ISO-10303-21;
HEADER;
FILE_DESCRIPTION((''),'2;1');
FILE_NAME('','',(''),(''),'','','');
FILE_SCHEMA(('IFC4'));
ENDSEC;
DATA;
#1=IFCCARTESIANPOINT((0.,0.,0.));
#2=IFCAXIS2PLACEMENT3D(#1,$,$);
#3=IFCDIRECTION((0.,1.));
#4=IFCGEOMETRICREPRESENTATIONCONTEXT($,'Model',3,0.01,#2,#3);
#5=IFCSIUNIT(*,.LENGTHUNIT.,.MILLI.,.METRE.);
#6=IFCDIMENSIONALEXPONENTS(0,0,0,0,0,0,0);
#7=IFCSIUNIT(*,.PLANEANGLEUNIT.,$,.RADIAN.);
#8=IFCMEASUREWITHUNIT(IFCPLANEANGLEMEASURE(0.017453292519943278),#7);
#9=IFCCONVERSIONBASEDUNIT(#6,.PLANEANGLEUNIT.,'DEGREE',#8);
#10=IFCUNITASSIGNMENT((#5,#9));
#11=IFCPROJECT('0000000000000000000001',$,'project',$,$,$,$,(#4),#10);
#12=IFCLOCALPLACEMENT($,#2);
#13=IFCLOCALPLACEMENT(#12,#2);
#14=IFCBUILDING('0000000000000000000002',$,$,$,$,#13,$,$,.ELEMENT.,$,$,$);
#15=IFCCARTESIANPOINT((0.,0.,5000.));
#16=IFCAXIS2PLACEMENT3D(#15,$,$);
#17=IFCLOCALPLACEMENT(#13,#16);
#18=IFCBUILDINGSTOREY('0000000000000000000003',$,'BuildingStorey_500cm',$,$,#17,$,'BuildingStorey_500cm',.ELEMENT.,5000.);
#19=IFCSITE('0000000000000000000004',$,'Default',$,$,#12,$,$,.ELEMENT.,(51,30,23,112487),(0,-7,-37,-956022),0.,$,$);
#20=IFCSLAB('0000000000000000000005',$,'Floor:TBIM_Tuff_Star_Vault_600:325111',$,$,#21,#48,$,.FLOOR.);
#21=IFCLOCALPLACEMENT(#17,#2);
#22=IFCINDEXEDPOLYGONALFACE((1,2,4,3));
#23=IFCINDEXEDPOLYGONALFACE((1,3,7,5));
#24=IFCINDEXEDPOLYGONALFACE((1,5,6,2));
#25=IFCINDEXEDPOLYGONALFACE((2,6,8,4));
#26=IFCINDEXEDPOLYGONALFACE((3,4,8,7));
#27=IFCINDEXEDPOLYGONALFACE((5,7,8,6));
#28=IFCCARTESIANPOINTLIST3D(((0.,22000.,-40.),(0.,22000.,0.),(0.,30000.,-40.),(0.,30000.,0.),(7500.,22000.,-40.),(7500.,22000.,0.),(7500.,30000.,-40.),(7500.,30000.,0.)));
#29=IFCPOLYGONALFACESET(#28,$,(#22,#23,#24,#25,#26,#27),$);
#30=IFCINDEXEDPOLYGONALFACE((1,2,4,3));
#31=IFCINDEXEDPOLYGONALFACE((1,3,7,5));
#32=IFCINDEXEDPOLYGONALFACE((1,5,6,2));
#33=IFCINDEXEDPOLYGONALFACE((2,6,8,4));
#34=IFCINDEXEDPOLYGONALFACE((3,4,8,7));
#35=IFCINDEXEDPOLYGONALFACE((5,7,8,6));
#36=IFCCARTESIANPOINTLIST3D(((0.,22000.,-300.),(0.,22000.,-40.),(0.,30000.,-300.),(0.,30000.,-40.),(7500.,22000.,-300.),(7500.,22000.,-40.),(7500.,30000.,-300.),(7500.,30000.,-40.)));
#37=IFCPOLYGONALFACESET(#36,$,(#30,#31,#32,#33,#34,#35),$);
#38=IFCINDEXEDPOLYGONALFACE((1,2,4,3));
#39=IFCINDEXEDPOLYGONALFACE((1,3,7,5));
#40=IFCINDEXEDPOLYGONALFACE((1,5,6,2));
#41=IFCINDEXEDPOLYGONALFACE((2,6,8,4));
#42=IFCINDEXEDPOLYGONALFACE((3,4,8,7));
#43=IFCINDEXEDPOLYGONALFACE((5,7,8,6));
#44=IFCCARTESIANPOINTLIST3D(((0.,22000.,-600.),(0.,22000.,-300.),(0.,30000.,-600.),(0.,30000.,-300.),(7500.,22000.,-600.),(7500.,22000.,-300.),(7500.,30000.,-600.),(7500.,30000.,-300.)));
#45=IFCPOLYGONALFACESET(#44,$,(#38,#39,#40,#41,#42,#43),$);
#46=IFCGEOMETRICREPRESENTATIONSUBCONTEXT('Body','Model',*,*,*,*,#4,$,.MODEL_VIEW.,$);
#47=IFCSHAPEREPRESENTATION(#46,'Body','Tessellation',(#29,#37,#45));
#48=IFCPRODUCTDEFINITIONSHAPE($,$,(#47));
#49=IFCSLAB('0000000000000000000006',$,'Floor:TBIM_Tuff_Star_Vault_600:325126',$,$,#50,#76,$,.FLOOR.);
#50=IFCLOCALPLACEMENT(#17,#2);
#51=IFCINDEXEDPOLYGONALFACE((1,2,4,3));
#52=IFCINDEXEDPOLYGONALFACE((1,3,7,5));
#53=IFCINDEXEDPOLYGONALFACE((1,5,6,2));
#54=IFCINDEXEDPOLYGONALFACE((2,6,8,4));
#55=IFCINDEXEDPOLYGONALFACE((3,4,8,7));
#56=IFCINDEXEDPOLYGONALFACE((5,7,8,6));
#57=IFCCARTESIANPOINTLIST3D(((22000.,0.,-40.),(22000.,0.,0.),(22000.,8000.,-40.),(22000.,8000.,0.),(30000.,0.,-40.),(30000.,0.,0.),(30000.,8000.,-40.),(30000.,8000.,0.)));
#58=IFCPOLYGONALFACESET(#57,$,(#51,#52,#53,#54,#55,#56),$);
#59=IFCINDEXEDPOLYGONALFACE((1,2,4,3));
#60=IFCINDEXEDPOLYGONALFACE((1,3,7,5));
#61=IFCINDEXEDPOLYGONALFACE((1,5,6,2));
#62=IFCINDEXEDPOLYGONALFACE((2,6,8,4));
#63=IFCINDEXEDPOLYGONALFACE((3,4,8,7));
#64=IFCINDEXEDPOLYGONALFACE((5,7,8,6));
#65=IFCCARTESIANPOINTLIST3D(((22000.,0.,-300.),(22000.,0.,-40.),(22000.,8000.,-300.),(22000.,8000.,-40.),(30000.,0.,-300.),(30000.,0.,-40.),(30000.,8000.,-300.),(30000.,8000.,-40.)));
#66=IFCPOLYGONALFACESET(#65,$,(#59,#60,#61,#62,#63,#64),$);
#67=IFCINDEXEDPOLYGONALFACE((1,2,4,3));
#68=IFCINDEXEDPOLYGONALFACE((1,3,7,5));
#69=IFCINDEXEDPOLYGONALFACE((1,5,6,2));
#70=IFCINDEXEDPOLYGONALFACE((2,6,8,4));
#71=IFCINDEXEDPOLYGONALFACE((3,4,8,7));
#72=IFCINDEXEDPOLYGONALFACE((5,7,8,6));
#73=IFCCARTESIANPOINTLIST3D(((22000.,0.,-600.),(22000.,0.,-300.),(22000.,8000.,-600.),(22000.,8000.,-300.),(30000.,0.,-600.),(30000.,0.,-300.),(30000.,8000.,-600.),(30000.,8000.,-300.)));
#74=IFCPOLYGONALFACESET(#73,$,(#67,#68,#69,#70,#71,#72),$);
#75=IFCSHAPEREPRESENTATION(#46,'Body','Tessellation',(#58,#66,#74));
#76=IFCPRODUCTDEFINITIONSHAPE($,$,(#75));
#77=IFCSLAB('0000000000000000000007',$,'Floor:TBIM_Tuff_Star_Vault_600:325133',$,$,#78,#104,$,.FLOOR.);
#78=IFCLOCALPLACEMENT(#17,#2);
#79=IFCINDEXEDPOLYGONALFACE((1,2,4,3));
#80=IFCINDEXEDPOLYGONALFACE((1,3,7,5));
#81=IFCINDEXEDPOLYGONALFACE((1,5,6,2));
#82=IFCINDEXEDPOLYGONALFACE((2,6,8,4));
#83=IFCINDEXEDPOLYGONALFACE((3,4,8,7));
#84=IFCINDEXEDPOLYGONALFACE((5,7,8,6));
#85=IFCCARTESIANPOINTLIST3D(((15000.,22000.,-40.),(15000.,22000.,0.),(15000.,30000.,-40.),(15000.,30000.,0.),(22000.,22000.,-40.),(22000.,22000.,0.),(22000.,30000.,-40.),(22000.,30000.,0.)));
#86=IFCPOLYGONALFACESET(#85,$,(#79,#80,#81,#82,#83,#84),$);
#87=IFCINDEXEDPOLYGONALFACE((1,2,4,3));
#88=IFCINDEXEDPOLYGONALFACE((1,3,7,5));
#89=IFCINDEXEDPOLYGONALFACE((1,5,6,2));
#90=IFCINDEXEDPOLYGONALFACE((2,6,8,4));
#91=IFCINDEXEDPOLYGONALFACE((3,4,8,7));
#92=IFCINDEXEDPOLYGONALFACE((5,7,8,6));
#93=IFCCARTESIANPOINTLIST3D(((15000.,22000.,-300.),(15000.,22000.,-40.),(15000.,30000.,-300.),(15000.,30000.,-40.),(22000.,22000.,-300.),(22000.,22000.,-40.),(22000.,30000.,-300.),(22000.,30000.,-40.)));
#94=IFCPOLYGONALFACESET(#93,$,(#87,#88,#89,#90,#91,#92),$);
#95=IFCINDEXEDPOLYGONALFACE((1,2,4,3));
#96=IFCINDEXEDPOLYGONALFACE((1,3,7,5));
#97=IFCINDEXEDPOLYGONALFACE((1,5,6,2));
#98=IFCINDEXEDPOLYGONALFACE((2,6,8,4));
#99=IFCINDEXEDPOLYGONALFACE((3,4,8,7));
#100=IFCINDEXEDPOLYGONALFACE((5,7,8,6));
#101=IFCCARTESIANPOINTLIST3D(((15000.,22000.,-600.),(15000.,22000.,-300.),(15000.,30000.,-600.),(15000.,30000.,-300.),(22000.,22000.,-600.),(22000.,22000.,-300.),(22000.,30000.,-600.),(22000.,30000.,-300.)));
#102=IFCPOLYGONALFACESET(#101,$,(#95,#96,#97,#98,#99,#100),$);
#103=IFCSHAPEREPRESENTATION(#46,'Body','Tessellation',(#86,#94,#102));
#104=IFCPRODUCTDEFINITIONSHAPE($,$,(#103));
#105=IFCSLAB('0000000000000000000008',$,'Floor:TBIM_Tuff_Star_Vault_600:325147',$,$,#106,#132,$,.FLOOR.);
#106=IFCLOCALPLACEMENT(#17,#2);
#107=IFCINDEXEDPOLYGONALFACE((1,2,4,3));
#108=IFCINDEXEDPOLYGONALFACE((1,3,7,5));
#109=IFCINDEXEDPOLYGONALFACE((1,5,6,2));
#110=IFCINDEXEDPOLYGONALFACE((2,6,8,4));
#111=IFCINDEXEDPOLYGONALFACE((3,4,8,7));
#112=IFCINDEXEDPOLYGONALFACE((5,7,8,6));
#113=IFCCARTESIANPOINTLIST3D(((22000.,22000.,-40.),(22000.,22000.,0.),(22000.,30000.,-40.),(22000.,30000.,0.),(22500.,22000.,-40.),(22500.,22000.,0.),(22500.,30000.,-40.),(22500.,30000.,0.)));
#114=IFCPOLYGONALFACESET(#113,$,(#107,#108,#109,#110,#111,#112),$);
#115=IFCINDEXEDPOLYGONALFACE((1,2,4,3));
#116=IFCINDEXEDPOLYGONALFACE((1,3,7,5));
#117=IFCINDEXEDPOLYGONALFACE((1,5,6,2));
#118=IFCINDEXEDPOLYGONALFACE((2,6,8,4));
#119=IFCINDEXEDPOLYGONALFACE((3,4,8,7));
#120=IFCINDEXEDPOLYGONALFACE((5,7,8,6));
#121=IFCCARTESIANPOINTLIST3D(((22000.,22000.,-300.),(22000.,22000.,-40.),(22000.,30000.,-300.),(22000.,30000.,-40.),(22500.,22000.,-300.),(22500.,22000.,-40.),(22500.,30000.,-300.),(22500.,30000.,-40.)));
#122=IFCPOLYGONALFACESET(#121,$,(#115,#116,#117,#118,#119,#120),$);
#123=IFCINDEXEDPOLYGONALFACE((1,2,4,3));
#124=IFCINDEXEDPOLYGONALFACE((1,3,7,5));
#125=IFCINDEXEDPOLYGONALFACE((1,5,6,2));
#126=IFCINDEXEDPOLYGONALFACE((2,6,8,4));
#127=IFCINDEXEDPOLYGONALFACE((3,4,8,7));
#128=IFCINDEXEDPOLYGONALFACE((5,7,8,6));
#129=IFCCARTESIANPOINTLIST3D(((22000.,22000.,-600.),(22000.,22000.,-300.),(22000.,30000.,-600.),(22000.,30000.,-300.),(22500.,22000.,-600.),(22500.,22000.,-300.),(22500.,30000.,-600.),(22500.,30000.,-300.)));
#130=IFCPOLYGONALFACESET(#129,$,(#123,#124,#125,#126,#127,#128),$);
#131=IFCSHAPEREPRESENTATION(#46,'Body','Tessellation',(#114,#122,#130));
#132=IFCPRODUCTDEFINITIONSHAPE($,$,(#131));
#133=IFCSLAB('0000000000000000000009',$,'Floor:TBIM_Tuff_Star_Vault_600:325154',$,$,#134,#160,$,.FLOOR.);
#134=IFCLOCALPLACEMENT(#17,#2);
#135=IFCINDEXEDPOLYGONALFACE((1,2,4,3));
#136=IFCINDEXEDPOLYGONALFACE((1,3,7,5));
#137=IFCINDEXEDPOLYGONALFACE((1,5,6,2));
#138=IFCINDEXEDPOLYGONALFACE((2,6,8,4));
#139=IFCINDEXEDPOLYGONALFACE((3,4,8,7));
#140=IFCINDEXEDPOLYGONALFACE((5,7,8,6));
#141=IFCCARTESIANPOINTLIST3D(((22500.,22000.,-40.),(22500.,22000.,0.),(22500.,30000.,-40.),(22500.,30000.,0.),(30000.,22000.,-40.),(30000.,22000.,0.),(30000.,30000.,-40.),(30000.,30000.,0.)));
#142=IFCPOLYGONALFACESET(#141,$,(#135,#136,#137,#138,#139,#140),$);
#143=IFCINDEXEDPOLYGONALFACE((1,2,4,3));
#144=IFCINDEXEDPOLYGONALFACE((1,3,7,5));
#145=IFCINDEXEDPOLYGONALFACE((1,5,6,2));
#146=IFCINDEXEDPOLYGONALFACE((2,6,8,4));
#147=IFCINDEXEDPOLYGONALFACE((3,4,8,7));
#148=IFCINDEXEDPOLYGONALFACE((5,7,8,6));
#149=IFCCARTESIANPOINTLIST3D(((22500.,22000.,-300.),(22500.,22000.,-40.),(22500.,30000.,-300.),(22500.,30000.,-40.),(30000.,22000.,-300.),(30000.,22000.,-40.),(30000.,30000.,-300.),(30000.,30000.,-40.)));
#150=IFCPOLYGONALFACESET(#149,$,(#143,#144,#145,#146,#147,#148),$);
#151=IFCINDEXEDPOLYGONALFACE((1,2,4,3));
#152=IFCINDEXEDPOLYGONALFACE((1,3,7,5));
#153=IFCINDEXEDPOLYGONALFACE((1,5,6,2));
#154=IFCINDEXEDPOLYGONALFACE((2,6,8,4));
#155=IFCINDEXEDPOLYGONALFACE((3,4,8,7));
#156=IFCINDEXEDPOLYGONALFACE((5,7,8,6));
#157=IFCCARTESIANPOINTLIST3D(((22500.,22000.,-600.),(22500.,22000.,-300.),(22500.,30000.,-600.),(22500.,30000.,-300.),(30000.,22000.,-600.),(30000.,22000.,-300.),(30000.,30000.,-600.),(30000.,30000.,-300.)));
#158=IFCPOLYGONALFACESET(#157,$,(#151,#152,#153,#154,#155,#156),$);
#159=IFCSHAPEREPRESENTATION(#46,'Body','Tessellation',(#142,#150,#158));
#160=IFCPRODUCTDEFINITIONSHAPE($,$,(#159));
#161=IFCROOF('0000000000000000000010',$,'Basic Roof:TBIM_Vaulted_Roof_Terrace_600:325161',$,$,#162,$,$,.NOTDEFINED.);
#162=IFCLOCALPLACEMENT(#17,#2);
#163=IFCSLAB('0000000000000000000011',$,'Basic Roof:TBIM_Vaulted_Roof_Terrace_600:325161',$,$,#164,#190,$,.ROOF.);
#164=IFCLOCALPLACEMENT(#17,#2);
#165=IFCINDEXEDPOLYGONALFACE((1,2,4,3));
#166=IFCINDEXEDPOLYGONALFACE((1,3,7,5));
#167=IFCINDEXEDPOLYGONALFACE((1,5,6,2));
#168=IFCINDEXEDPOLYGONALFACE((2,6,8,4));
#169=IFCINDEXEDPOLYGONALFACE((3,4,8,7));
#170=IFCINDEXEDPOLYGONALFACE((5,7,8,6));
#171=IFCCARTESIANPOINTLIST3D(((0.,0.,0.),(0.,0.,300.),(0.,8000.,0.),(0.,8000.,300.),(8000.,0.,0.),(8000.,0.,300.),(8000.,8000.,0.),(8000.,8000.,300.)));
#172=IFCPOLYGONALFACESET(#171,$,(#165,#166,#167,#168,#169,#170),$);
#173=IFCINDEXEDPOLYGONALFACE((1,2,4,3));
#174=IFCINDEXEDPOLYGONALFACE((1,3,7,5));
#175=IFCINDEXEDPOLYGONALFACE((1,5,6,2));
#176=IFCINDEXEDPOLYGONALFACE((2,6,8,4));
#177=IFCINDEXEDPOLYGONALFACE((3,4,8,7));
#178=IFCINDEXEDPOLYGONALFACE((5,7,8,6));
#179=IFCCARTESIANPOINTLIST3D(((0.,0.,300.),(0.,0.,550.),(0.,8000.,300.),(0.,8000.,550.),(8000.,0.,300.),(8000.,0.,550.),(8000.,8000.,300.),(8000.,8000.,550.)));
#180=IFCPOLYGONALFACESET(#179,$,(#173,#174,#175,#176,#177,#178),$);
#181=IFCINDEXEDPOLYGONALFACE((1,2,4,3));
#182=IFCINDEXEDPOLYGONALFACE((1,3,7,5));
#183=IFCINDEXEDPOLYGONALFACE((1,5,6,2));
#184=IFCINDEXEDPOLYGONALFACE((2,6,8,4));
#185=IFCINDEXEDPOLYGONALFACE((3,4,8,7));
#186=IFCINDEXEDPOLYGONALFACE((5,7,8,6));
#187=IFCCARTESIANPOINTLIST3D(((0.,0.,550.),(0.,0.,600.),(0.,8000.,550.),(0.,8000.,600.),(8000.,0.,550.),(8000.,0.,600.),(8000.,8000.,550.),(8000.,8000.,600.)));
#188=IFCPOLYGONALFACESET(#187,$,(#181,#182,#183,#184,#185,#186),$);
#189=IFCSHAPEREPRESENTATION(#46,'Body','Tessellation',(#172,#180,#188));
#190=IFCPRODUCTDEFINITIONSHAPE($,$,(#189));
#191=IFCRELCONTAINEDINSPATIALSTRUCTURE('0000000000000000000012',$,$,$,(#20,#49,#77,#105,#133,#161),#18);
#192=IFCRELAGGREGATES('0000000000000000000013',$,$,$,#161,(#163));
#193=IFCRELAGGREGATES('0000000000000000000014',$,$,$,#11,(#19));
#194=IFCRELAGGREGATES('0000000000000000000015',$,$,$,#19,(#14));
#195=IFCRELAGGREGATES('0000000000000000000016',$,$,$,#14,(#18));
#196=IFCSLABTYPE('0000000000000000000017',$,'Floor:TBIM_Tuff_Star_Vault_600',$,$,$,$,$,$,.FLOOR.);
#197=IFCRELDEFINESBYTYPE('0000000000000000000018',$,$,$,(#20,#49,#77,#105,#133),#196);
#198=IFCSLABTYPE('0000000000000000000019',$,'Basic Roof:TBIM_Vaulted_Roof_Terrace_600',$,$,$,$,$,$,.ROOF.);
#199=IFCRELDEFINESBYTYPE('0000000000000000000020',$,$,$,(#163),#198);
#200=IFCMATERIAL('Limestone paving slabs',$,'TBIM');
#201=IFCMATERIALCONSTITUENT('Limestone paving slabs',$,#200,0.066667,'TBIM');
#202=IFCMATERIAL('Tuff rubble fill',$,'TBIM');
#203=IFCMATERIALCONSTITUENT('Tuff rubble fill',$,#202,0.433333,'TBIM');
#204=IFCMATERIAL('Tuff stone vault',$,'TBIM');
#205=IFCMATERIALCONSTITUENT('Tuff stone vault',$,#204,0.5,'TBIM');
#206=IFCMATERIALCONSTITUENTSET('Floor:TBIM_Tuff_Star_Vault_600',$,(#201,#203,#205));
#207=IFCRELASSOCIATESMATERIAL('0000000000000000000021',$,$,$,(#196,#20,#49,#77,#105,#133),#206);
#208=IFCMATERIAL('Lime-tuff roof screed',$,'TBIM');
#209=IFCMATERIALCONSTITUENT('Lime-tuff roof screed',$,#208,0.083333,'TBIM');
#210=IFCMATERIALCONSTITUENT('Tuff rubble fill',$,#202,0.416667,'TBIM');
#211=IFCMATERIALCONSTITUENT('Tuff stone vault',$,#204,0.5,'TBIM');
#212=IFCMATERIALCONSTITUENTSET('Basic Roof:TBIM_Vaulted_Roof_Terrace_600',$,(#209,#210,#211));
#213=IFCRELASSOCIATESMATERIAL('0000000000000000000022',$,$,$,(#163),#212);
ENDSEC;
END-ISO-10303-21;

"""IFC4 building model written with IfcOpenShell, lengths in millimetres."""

from ifc_helpers import new_model, entity, si_unit, converted_unit, direction, frame, origin, place, context, subcontext, project, spatial, indexed_curve, outline, extrude, material, constituent, constituent_set, type_object, element, aggregate, save


model = new_model("IFC4")

# Units and contexts
model_context = context("Model", 3, precision=0.01, world=origin(), true_north=direction((0.0, 1.0)))
body_context = subcontext(model_context, "Body", "Model", "MODEL_VIEW")
ifc_project = project(units=[si_unit("LENGTHUNIT", "METRE", prefix="MILLI"), converted_unit("PLANEANGLEUNIT", "DEGREE", entity("IfcPlaneAngleMeasure", 0.017453292519943278), si_unit("PLANEANGLEUNIT", "RADIAN"), dimensions=[0, 0, 0, 0, 0, 0, 0])], contexts=[model_context])

# Site, building, storey
site_placement = place(None, origin())
site = spatial("IfcSite", under=ifc_project, at=site_placement, Name="Default", CompositionType="ELEMENT", RefLatitude=(51, 30, 23, 112487), RefLongitude=(0, -7, -37, -956022), RefElevation=0.0)
building_placement = place(site_placement, origin())
building = spatial("IfcBuilding", under=site, at=building_placement, CompositionType="ELEMENT")
storey_placement = place(building_placement, frame((0.0, 0.0, 5000.0)))
storey = spatial("IfcBuildingStorey", under=building, at=storey_placement, Name="BuildingStorey_500cm", LongName="BuildingStorey_500cm", CompositionType="ELEMENT", Elevation=5000.0)

# Slabs
ifc_material_1 = material(Name="Limestone paving slabs", Category="TBIM")
ifc_constituent_1 = constituent(ifc_material_1, Name="Limestone paving slabs", Category="TBIM", fraction=0.066667)
ifc_material_2 = material(Name="Tuff rubble fill", Category="TBIM")
ifc_constituent_2 = constituent(ifc_material_2, Name="Tuff rubble fill", Category="TBIM", fraction=0.433333)
ifc_material_3 = material(Name="Tuff stone vault", Category="TBIM")
ifc_constituent_3 = constituent(ifc_material_3, Name="Tuff stone vault", Category="TBIM", fraction=0.5)
ifc_constituent_set_1 = constituent_set(constituents=[ifc_constituent_1, ifc_constituent_2, ifc_constituent_3], Name="Floor:TBIM_Tuff_Star_Vault_600")
slab_type_1 = type_object("IfcSlabType", Name="Floor:TBIM_Tuff_Star_Vault_600", PredefinedType="FLOOR", material=ifc_constituent_set_1)
slab_1_placement = place(storey_placement, origin())
element("IfcSlab", 1, at=slab_1_placement, inside=storey, type_object=slab_type_1, material=ifc_constituent_set_1, Name="Floor:TBIM_Tuff_Star_Vault_600:325111", PredefinedType="FLOOR", context=body_context, shape_type="SweptSolid", body=[
    extrude(outline(indexed_curve([(-4000.0, -3750.0), (4000.0, -3750.0), (4000.0, 3750.0), (-4000.0, 3750.0), (-4000.0, -3750.0)], self_intersect=False)), frame((3750.0, 26000.0, -40.0), z_axis=(0.0, 0.0, 1.0), x_axis=(0.0, -1.0, 0.0)), (0.0, 0.0, 1.0), 40.0),
    extrude(outline(indexed_curve([(-4000.0, -3750.0), (4000.0, -3750.0), (4000.0, 3750.0), (-4000.0, 3750.0), (-4000.0, -3750.0)], self_intersect=False)), frame((3750.0, 26000.0, -300.0), z_axis=(0.0, 0.0, 1.0), x_axis=(0.0, -1.0, 0.0)), (0.0, 0.0, 1.0), 260.0),
    extrude(outline(indexed_curve([(-4000.0, -3750.0), (4000.0, -3750.0), (4000.0, 3750.0), (-4000.0, 3750.0), (-4000.0, -3750.0)], self_intersect=False)), frame((3750.0, 26000.0, -600.0), z_axis=(0.0, 0.0, 1.0), x_axis=(0.0, -1.0, 0.0)), (0.0, 0.0, 1.0), 300.0),
])
slab_2_placement = place(storey_placement, origin())
element("IfcSlab", 2, at=slab_2_placement, inside=storey, type_object=slab_type_1, material=ifc_constituent_set_1, Name="Floor:TBIM_Tuff_Star_Vault_600:325126", PredefinedType="FLOOR", context=body_context, shape_type="SweptSolid", body=[
    extrude(outline(indexed_curve([(-4000.0, -4000.0), (4000.0, -4000.0), (4000.0, 4000.0), (-4000.0, 4000.0), (-4000.0, -4000.0)], self_intersect=False)), frame((26000.0, 4000.0, -40.0), z_axis=(0.0, 0.0, 1.0), x_axis=(-1.0, 0.0, 0.0)), (0.0, 0.0, 1.0), 40.0),
    extrude(outline(indexed_curve([(-4000.0, -4000.0), (4000.0, -4000.0), (4000.0, 4000.0), (-4000.0, 4000.0), (-4000.0, -4000.0)], self_intersect=False)), frame((26000.0, 4000.0, -300.0), z_axis=(0.0, 0.0, 1.0), x_axis=(-1.0, 0.0, 0.0)), (0.0, 0.0, 1.0), 260.0),
    extrude(outline(indexed_curve([(-4000.0, -4000.0), (4000.0, -4000.0), (4000.0, 4000.0), (-4000.0, 4000.0), (-4000.0, -4000.0)], self_intersect=False)), frame((26000.0, 4000.0, -600.0), z_axis=(0.0, 0.0, 1.0), x_axis=(-1.0, 0.0, 0.0)), (0.0, 0.0, 1.0), 300.0),
])
slab_3_placement = place(storey_placement, origin())
element("IfcSlab", 3, at=slab_3_placement, inside=storey, type_object=slab_type_1, material=ifc_constituent_set_1, Name="Floor:TBIM_Tuff_Star_Vault_600:325133", PredefinedType="FLOOR", context=body_context, shape_type="SweptSolid", body=[
    extrude(outline(indexed_curve([(-3500.0, -4000.0), (3500.0, -4000.0), (3500.0, 4000.0), (-3500.0, 4000.0), (-3500.0, -4000.0)], self_intersect=False)), frame((18500.0, 26000.0, -40.0), z_axis=(0.0, 0.0, 1.0), x_axis=(-1.0, 0.0, 0.0)), (0.0, 0.0, 1.0), 40.0),
    extrude(outline(indexed_curve([(-3500.0, -4000.0), (3500.0, -4000.0), (3500.0, 4000.0), (-3500.0, 4000.0), (-3500.0, -4000.0)], self_intersect=False)), frame((18500.0, 26000.0, -300.0), z_axis=(0.0, 0.0, 1.0), x_axis=(-1.0, 0.0, 0.0)), (0.0, 0.0, 1.0), 260.0),
    extrude(outline(indexed_curve([(-3500.0, -4000.0), (3500.0, -4000.0), (3500.0, 4000.0), (-3500.0, 4000.0), (-3500.0, -4000.0)], self_intersect=False)), frame((18500.0, 26000.0, -600.0), z_axis=(0.0, 0.0, 1.0), x_axis=(-1.0, 0.0, 0.0)), (0.0, 0.0, 1.0), 300.0),
])
slab_4_placement = place(storey_placement, origin())
element("IfcSlab", 4, at=slab_4_placement, inside=storey, type_object=slab_type_1, material=ifc_constituent_set_1, Name="Floor:TBIM_Tuff_Star_Vault_600:325147", PredefinedType="FLOOR", context=body_context, shape_type="SweptSolid", body=[
    extrude(outline(indexed_curve([(-250.0, -4000.0), (250.0, -4000.0), (250.0, 4000.0), (-250.0, 4000.0), (-250.0, -4000.0)], self_intersect=False)), frame((22250.0, 26000.0, -40.0), z_axis=(0.0, 0.0, 1.0), x_axis=(-1.0, 0.0, 0.0)), (0.0, 0.0, 1.0), 40.0),
    extrude(outline(indexed_curve([(-250.0, -4000.0), (250.0, -4000.0), (250.0, 4000.0), (-250.0, 4000.0), (-250.0, -4000.0)], self_intersect=False)), frame((22250.0, 26000.0, -300.0), z_axis=(0.0, 0.0, 1.0), x_axis=(-1.0, 0.0, 0.0)), (0.0, 0.0, 1.0), 260.0),
    extrude(outline(indexed_curve([(-250.0, -4000.0), (250.0, -4000.0), (250.0, 4000.0), (-250.0, 4000.0), (-250.0, -4000.0)], self_intersect=False)), frame((22250.0, 26000.0, -600.0), z_axis=(0.0, 0.0, 1.0), x_axis=(-1.0, 0.0, 0.0)), (0.0, 0.0, 1.0), 300.0),
])
slab_5_placement = place(storey_placement, origin())
element("IfcSlab", 5, at=slab_5_placement, inside=storey, type_object=slab_type_1, material=ifc_constituent_set_1, Name="Floor:TBIM_Tuff_Star_Vault_600:325154", PredefinedType="FLOOR", context=body_context, shape_type="SweptSolid", body=[
    extrude(outline(indexed_curve([(-3750.0, -4000.0), (3750.0, -4000.0), (3750.0, 4000.0), (-3750.0, 4000.0), (-3750.0, -4000.0)], self_intersect=False)), frame((26250.0, 26000.0, -40.0), z_axis=(0.0, 0.0, 1.0), x_axis=(-1.0, 0.0, 0.0)), (0.0, 0.0, 1.0), 40.0),
    extrude(outline(indexed_curve([(-3750.0, -4000.0), (3750.0, -4000.0), (3750.0, 4000.0), (-3750.0, 4000.0), (-3750.0, -4000.0)], self_intersect=False)), frame((26250.0, 26000.0, -300.0), z_axis=(0.0, 0.0, 1.0), x_axis=(-1.0, 0.0, 0.0)), (0.0, 0.0, 1.0), 260.0),
    extrude(outline(indexed_curve([(-3750.0, -4000.0), (3750.0, -4000.0), (3750.0, 4000.0), (-3750.0, 4000.0), (-3750.0, -4000.0)], self_intersect=False)), frame((26250.0, 26000.0, -600.0), z_axis=(0.0, 0.0, 1.0), x_axis=(-1.0, 0.0, 0.0)), (0.0, 0.0, 1.0), 300.0),
])

# Roof, slab
roof_1_placement = place(storey_placement, origin())
roof_1 = element("IfcRoof", 6, at=roof_1_placement, inside=storey, Name="Basic Roof:TBIM_Vaulted_Roof_Terrace_600:325161", PredefinedType="NOTDEFINED")
ifc_material_4 = material(Name="Lime-tuff roof screed", Category="TBIM")
ifc_constituent_4 = constituent(ifc_material_4, Name="Lime-tuff roof screed", Category="TBIM", fraction=0.083333)
ifc_constituent_5 = constituent(ifc_material_2, Name="Tuff rubble fill", Category="TBIM", fraction=0.416667)
ifc_constituent_6 = constituent(ifc_material_3, Name="Tuff stone vault", Category="TBIM", fraction=0.5)
ifc_constituent_set_2 = constituent_set(constituents=[ifc_constituent_4, ifc_constituent_5, ifc_constituent_6], Name="Basic Roof:TBIM_Vaulted_Roof_Terrace_600")
slab_type_2 = type_object("IfcSlabType", Name="Basic Roof:TBIM_Vaulted_Roof_Terrace_600", PredefinedType="ROOF")
slab_6_placement = place(roof_1_placement, origin())
slab_6 = element("IfcSlab", 7, at=slab_6_placement, type_object=slab_type_2, material=ifc_constituent_set_2, Name="Basic Roof:TBIM_Vaulted_Roof_Terrace_600:325161", PredefinedType="ROOF", context=body_context, shape_type="SweptSolid", body=[
    extrude(outline(indexed_curve([(-4000.0, 4000.0), (-4000.0, -4000.0), (4000.0, -4000.0), (4000.0, 4000.0), (-4000.0, 4000.0)], self_intersect=False)), frame((4000.0, 4000.0, 0.0)), (0.0, 0.0, 1.0), 300.0),
    extrude(outline(indexed_curve([(-4000.0, 4000.0), (-4000.0, -4000.0), (4000.0, -4000.0), (4000.0, 4000.0), (-4000.0, 4000.0)], self_intersect=False)), frame((4000.0, 4000.0, 300.0)), (0.0, 0.0, 1.0), 250.0),
    extrude(outline(indexed_curve([(-4000.0, 4000.0), (-4000.0, -4000.0), (4000.0, -4000.0), (4000.0, 4000.0), (-4000.0, 4000.0)], self_intersect=False)), frame((4000.0, 4000.0, 550.0)), (0.0, 0.0, 1.0), 50.0),
])
aggregate(roof_1, [slab_6])

save(model, "model.ifc")
